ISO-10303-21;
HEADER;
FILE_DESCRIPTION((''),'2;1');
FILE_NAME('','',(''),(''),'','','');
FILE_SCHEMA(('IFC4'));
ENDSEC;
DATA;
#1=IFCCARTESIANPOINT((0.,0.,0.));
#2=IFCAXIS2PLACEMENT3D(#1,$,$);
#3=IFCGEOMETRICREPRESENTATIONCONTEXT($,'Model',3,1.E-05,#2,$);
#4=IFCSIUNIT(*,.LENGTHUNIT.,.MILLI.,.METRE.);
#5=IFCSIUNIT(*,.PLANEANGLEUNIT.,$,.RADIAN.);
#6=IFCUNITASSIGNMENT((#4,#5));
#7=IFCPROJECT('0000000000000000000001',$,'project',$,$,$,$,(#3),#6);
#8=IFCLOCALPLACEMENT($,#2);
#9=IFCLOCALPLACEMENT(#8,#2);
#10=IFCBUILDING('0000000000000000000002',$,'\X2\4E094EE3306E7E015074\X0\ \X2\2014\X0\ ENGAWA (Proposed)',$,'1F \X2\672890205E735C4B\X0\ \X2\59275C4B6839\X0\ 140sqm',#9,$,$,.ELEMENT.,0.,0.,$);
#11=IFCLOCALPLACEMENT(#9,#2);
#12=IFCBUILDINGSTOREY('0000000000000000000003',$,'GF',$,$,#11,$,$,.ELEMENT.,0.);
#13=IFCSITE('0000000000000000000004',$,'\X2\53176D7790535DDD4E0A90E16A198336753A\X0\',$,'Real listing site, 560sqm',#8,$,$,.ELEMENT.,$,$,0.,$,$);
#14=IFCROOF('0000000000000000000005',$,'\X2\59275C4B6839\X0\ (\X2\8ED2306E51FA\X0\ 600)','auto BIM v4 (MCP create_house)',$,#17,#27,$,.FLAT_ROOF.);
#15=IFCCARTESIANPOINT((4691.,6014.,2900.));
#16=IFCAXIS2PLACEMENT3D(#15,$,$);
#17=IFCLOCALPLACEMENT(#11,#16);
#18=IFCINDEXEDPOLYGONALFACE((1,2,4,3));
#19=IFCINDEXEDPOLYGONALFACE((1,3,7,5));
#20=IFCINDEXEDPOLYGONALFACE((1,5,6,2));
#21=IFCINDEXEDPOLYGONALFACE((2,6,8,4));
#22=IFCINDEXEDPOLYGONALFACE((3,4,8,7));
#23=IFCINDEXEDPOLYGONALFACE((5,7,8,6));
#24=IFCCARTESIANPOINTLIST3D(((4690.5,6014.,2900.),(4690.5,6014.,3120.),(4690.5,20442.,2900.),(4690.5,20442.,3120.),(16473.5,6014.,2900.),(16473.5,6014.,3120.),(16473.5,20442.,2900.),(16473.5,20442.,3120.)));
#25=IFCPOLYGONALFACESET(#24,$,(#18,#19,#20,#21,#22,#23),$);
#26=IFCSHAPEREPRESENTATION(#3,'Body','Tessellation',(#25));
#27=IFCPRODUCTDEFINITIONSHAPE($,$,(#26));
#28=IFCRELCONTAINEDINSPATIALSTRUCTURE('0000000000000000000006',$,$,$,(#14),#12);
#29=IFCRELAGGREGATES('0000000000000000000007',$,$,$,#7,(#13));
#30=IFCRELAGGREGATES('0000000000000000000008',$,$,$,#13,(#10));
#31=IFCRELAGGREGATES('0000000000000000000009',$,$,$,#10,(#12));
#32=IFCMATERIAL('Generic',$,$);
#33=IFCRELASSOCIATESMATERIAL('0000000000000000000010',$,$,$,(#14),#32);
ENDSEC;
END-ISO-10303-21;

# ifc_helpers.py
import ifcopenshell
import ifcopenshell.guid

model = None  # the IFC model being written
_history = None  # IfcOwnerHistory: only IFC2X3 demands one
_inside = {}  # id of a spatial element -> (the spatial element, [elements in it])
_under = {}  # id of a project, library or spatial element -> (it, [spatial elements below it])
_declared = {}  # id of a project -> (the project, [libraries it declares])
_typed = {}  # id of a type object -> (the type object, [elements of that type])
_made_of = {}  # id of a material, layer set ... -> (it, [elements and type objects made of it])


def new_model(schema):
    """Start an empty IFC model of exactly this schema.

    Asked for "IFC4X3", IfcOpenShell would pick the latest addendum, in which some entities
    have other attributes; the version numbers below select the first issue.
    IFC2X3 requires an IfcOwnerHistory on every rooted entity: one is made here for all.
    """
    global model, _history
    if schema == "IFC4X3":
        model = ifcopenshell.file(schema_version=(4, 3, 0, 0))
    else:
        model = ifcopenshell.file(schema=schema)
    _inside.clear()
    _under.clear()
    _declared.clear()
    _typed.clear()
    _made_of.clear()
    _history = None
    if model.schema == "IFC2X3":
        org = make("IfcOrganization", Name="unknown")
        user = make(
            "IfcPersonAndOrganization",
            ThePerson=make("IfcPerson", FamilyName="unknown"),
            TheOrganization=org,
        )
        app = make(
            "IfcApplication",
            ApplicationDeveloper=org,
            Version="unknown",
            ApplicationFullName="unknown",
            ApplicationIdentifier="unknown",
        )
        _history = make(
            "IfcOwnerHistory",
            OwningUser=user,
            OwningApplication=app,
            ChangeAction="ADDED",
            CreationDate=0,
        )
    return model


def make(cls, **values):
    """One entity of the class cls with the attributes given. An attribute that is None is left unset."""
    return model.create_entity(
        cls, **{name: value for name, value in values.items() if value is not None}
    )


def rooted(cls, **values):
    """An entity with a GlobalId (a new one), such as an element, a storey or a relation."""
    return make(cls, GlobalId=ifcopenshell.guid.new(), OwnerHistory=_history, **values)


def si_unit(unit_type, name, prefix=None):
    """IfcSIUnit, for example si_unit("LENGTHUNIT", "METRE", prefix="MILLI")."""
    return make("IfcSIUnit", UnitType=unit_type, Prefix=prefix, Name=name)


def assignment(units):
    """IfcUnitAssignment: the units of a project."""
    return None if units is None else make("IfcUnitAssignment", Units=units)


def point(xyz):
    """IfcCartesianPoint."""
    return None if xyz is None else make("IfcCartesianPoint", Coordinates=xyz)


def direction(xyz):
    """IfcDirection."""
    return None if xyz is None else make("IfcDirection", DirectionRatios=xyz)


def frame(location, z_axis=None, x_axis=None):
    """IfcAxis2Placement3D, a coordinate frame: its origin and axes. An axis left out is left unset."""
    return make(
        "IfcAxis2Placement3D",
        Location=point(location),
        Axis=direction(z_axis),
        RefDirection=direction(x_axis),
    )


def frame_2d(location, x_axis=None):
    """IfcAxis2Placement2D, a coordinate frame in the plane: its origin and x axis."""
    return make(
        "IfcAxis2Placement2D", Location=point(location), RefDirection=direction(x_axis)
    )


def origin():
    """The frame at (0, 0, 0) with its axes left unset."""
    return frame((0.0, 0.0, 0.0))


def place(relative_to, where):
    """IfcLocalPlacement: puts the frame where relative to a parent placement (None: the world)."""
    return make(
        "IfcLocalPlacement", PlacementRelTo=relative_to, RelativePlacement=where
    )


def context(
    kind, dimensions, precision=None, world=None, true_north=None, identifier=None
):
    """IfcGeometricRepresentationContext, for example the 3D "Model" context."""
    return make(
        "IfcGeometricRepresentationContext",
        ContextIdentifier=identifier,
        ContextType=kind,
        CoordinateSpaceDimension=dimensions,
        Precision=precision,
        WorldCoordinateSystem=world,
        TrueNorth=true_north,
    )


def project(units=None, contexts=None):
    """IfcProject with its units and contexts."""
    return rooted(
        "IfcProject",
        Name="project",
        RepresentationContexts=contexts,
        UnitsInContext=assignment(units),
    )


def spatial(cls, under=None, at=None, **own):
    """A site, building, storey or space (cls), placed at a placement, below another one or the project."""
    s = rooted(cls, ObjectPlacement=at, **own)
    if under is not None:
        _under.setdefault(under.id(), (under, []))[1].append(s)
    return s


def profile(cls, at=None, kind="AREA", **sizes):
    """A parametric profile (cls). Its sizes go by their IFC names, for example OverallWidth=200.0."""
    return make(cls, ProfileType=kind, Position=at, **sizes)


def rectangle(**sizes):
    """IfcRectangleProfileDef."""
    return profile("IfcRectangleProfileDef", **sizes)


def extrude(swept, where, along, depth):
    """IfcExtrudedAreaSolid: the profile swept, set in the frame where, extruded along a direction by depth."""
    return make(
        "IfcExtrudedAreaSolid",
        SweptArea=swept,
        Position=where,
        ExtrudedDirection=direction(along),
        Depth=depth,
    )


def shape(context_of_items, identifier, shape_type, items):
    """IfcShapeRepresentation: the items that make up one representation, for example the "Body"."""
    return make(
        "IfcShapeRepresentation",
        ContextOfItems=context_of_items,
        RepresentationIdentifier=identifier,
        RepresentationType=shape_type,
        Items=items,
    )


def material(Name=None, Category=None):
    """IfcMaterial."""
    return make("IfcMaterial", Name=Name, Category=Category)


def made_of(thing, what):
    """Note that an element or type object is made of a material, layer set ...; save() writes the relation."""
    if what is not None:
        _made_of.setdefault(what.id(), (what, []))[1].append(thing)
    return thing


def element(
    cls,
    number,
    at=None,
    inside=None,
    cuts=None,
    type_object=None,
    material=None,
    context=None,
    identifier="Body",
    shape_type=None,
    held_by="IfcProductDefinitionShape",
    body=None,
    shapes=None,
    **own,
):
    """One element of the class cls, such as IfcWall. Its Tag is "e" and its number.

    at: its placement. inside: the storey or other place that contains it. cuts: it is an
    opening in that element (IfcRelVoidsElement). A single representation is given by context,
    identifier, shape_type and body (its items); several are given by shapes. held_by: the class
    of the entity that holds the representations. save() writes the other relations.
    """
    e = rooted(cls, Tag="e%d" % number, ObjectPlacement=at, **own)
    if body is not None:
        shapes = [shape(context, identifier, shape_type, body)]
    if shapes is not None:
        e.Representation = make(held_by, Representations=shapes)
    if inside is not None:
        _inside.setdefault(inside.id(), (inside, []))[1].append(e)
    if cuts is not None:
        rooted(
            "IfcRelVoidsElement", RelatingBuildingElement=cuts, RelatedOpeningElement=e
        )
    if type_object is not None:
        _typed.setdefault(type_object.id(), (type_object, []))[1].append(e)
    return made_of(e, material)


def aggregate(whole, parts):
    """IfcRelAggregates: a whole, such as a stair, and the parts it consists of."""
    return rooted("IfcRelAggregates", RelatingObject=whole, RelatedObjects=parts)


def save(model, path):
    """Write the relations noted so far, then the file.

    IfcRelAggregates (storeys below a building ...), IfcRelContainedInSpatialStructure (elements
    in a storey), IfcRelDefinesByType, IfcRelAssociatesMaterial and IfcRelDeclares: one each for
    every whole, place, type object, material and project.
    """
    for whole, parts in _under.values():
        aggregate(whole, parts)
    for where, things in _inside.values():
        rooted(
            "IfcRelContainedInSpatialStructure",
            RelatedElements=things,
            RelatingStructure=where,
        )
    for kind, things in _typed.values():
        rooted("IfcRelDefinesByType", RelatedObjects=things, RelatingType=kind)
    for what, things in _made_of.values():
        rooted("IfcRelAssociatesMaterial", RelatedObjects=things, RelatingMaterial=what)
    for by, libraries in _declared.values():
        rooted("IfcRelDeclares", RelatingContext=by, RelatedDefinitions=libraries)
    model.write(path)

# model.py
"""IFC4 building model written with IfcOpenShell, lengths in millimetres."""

from ifc_helpers import new_model, si_unit, frame, frame_2d, origin, place, context, project, spatial, rectangle, extrude, material, element, save


model = new_model("IFC4")

# Units and contexts
model_context = context("Model", 3, precision=1e-05, world=origin())
ifc_project = project(units=[si_unit("LENGTHUNIT", "METRE", prefix="MILLI"), si_unit("PLANEANGLEUNIT", "RADIAN")], contexts=[model_context])

# Site, building, storey
site_placement = place(None, origin())
site = spatial("IfcSite", under=ifc_project, at=site_placement, Name="北海道川上郡標茶町", ObjectType="Real listing site, 560sqm", CompositionType="ELEMENT", RefElevation=0.0)
building_placement = place(site_placement, origin())
building = spatial("IfcBuilding", under=site, at=building_placement, Name="三代の縁側 — ENGAWA (Proposed)", ObjectType="1F 木造平屋 大屋根 140sqm", CompositionType="ELEMENT", ElevationOfRefHeight=0.0, ElevationOfTerrain=0.0)
storey_placement = place(building_placement, origin())
storey = spatial("IfcBuildingStorey", under=building, at=storey_placement, Name="GF", CompositionType="ELEMENT", Elevation=0.0)

# Shared definitions
ifc_material = material(Name="Generic")

# Roof
roof_placement = place(storey_placement, frame((4691.0, 6014.0, 2900.0)))
element("IfcRoof", 1, at=roof_placement, inside=storey, material=ifc_material, Name="大屋根 (軒の出 600)", Description="auto BIM v4 (MCP create_house)", PredefinedType="FLAT_ROOF", context=model_context, shape_type="SweptSolid", body=[
    extrude(rectangle(XDim=11783.0, YDim=14428.0, at=frame_2d((5891.0, 7214.0))), frame((4691.0, 6014.0, 2900.0)), (0.0, 0.0, 1.0), 220.0),
])

save(model, "model.ifc")
